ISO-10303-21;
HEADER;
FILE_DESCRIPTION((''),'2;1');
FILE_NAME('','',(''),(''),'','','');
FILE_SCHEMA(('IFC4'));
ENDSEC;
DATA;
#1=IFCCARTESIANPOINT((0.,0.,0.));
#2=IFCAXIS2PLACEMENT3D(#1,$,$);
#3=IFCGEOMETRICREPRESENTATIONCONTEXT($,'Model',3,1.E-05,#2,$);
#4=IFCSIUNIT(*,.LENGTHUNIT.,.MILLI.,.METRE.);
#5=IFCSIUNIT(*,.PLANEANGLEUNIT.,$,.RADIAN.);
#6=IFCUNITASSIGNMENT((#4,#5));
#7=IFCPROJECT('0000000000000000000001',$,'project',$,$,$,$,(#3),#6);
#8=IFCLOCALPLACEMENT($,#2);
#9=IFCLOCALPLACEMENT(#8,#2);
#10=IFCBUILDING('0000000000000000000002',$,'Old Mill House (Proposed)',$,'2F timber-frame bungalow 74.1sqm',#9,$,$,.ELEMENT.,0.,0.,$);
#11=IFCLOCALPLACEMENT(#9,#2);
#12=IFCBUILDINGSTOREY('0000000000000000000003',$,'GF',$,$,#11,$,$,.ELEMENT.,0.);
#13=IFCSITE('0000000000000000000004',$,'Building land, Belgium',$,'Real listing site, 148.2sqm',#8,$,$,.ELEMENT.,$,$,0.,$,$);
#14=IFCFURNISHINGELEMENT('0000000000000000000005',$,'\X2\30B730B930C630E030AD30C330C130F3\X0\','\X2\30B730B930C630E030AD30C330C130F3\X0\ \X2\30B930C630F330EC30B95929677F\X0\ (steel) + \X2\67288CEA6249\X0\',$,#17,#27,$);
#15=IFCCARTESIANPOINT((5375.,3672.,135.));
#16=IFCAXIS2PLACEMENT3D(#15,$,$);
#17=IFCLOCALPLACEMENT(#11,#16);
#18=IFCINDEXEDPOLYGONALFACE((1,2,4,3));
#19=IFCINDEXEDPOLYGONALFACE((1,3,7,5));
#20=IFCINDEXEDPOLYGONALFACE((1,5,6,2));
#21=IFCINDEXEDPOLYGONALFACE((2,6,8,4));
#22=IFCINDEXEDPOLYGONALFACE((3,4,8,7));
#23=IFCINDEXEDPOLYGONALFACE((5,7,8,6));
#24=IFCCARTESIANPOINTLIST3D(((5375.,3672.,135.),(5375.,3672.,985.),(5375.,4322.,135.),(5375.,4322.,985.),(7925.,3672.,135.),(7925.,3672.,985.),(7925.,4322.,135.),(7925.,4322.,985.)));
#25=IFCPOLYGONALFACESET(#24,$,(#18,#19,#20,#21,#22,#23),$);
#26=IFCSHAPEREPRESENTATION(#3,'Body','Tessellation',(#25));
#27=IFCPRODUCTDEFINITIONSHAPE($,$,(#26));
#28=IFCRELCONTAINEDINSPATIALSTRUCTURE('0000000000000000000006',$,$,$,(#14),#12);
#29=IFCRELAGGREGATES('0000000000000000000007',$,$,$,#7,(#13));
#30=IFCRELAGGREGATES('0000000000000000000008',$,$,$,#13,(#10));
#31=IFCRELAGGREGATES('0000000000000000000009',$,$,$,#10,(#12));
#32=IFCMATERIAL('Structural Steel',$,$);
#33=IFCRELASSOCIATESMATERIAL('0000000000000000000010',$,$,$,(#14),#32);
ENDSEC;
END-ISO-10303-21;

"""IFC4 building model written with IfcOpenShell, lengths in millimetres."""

from ifc_helpers import new_model, si_unit, frame, frame_2d, origin, place, context, project, spatial, rectangle, extrude, material, element, save


model = new_model("IFC4")

# Units and contexts
model_context = context("Model", 3, precision=1e-05, world=origin())
ifc_project = project(units=[si_unit("LENGTHUNIT", "METRE", prefix="MILLI"), si_unit("PLANEANGLEUNIT", "RADIAN")], contexts=[model_context])

# Site, building, storey
site_placement = place(None, origin())
site = spatial("IfcSite", under=ifc_project, at=site_placement, Name="Building land, Belgium", ObjectType="Real listing site, 148.2sqm", CompositionType="ELEMENT", RefElevation=0.0)
building_placement = place(site_placement, origin())
building = spatial("IfcBuilding", under=site, at=building_placement, Name="Old Mill House (Proposed)", ObjectType="2F timber-frame bungalow 74.1sqm", CompositionType="ELEMENT", ElevationOfRefHeight=0.0, ElevationOfTerrain=0.0)
storey_placement = place(building_placement, origin())
storey = spatial("IfcBuildingStorey", under=building, at=storey_placement, Name="GF", CompositionType="ELEMENT", Elevation=0.0)

# Furnishing element
ifc_material_1 = material(Name="Structural Steel")
furnishing_1_placement = place(storey_placement, frame((5375.0, 3672.0, 135.0)))
element("IfcFurnishingElement", 1, at=furnishing_1_placement, inside=storey, material=ifc_material_1, Name="システムキッチン", Description="システムキッチン ステンレス天板 (steel) + 木質扉", context=model_context, shape_type="SweptSolid", body=[
    extrude(rectangle(XDim=2550.0, YDim=650.0, at=frame_2d((1275.0, 325.0))), frame((5375.0, 3672.0, 135.0)), (0.0, 0.0, 1.0), 850.0),
])

save(model, "model.ifc")
